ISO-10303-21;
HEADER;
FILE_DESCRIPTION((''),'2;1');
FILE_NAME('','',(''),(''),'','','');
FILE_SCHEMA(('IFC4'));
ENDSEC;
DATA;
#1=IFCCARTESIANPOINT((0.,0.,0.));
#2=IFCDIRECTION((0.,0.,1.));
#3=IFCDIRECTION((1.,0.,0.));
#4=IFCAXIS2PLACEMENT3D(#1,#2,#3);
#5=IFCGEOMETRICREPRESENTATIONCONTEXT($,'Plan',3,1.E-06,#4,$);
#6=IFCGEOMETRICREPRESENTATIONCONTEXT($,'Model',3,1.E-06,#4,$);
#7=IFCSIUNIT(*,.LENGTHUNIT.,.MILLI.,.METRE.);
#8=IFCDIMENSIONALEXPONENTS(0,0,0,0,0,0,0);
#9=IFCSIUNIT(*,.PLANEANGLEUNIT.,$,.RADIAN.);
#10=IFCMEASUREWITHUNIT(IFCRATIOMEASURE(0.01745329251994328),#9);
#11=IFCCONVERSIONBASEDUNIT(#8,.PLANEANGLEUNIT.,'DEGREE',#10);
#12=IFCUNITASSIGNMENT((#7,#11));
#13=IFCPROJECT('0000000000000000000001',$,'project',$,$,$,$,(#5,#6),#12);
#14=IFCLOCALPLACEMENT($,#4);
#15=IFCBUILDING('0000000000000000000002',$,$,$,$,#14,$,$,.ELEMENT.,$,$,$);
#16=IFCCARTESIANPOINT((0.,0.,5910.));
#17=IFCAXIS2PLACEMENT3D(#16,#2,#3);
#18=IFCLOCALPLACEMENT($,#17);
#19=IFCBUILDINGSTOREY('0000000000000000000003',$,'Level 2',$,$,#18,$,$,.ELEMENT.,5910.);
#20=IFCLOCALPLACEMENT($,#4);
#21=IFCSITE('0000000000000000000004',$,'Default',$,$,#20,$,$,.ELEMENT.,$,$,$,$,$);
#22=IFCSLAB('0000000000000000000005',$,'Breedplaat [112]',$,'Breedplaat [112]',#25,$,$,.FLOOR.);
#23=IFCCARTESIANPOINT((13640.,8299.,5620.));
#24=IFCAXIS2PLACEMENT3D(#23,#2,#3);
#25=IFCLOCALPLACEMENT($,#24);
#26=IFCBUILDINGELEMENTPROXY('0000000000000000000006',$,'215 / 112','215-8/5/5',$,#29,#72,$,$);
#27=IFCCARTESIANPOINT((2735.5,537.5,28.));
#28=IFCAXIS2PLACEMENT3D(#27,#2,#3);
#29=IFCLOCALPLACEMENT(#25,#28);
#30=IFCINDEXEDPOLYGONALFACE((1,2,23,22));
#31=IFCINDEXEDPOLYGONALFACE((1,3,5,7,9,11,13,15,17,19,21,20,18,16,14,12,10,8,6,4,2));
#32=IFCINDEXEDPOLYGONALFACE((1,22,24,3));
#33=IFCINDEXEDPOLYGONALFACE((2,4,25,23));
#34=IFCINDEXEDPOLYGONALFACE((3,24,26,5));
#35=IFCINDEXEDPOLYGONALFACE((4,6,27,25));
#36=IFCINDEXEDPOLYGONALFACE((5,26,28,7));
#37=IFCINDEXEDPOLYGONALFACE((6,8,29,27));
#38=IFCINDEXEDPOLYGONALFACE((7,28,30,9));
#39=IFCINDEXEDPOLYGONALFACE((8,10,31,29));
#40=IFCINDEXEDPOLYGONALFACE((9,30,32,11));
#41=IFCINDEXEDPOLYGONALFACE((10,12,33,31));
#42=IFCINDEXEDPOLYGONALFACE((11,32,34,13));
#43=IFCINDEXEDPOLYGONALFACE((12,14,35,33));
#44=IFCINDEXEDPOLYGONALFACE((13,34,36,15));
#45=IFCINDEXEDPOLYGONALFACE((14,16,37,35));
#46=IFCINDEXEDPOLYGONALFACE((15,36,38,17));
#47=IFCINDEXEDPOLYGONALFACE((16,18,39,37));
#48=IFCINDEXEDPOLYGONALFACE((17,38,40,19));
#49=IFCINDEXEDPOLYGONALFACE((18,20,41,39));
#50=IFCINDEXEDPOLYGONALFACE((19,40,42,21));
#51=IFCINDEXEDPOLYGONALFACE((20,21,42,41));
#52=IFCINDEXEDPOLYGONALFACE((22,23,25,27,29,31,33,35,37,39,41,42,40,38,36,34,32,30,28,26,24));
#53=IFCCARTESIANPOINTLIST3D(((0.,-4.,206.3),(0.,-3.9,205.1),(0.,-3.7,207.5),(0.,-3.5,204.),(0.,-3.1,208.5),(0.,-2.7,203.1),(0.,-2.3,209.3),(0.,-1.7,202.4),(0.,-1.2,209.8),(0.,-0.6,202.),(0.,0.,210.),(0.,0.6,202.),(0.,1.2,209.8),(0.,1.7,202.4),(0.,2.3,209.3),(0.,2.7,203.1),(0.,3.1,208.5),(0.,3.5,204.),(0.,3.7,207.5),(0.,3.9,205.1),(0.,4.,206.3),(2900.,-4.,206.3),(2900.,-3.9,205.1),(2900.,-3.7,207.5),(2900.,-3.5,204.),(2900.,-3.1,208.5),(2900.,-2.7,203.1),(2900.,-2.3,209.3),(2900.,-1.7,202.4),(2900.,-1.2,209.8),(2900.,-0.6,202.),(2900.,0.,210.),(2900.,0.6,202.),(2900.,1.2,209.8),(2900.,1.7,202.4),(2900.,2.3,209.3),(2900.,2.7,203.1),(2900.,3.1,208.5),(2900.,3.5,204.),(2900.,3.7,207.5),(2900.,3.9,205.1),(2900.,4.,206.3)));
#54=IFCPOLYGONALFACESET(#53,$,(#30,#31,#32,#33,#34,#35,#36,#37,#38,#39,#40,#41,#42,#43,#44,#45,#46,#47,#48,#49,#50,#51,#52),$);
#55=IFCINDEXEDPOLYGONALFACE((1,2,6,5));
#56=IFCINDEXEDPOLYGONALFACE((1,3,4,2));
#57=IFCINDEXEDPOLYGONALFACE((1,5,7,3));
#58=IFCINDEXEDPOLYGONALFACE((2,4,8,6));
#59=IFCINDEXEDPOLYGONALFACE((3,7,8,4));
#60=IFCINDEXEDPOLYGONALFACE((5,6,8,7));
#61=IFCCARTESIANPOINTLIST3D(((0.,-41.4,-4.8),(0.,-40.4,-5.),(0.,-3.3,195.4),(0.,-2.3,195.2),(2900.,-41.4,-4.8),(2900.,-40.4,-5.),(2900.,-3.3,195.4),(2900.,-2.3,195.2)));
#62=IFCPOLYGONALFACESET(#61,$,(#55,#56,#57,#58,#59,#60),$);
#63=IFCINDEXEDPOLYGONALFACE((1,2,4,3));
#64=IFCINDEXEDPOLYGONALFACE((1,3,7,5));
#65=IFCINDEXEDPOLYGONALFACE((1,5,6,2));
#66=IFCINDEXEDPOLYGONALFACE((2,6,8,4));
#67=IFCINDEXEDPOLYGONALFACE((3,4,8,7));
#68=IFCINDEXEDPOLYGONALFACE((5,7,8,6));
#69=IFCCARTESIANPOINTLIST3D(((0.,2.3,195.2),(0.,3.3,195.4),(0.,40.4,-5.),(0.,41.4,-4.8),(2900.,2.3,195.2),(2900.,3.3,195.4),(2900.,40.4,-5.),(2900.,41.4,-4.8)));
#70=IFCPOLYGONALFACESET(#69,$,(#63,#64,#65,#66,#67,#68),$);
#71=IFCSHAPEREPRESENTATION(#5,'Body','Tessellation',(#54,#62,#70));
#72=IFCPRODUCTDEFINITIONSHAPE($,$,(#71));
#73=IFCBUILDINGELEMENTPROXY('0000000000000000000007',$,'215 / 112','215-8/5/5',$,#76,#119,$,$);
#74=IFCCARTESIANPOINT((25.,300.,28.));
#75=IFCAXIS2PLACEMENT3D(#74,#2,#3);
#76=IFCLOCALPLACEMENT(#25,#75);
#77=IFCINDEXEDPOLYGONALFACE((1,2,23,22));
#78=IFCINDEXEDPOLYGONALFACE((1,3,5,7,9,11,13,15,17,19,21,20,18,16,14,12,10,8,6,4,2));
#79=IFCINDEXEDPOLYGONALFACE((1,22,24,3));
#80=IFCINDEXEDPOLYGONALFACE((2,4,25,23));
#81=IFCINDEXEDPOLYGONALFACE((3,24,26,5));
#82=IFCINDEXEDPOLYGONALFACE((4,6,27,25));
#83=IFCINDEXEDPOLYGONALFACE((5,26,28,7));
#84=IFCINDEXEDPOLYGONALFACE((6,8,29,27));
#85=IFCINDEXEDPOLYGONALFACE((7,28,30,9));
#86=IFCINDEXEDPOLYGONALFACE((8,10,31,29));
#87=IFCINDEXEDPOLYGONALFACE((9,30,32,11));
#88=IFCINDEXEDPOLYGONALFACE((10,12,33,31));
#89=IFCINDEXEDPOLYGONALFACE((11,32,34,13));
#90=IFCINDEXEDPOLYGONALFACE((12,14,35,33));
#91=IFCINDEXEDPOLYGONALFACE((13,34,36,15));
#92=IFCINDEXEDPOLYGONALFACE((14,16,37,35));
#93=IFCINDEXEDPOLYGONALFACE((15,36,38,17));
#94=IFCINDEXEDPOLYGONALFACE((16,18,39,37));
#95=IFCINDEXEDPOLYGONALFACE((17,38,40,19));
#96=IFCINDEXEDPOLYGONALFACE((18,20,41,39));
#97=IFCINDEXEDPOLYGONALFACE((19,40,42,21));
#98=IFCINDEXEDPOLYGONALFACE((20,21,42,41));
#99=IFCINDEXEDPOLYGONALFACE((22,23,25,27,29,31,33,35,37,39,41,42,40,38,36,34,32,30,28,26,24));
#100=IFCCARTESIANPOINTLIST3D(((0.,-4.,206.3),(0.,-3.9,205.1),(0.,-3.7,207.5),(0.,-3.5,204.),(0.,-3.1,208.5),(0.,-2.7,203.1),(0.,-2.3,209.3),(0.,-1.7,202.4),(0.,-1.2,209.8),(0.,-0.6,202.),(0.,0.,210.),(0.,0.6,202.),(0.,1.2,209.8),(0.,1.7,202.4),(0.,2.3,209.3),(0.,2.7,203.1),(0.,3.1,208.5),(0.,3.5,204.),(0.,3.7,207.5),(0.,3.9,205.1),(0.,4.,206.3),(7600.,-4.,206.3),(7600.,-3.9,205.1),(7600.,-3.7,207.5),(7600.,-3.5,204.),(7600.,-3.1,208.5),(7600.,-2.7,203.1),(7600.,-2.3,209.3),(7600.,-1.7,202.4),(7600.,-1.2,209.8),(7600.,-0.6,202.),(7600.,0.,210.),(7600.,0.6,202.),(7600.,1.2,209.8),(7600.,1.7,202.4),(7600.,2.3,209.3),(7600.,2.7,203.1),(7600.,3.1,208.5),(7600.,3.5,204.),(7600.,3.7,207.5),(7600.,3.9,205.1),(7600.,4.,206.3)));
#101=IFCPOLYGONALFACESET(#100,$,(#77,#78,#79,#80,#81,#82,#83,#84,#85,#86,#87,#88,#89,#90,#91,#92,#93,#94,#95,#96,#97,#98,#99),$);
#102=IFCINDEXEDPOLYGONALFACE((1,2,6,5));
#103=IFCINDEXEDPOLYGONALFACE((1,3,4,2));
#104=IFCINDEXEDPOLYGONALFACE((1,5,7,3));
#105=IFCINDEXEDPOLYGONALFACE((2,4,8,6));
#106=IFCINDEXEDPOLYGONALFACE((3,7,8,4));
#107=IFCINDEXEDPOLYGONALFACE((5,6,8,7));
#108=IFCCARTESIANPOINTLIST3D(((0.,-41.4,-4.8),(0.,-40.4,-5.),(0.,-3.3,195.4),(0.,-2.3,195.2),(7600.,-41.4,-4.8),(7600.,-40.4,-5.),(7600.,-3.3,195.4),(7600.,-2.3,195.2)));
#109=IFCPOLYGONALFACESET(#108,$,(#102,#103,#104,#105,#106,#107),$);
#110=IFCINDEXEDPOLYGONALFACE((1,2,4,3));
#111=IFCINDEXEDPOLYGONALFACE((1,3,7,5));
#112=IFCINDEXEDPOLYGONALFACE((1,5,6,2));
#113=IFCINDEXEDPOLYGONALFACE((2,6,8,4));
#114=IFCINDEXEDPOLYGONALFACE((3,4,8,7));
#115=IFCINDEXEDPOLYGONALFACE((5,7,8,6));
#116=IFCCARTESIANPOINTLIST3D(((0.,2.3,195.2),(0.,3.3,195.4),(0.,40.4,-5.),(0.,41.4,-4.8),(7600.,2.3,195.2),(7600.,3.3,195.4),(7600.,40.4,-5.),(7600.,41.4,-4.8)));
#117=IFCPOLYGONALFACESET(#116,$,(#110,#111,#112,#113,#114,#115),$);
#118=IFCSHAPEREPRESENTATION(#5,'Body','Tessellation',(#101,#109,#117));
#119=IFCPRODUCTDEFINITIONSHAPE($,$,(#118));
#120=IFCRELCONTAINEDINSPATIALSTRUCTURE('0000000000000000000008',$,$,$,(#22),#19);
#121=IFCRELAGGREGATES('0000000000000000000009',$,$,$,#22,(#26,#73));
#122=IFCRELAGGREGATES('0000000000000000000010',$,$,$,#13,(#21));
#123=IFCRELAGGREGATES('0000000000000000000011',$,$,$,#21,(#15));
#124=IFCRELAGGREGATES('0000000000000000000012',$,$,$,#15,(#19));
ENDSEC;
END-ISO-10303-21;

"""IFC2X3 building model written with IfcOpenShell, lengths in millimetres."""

from ifc_helpers import new_model, entity, si_unit, converted_unit, frame, origin_with_axes, origin_2d_with_axis, place, context, project, spatial, rectangle, circle, extrude, element, aggregate, save


model = new_model("IFC2X3")

# Units and contexts
plan_context = context("Plan", 3, precision=1e-06, world=origin_with_axes())
model_context = context("Model", 3, precision=1e-06, world=origin_with_axes())
ifc_project = project(units=[si_unit("LENGTHUNIT", "METRE", prefix="MILLI"), converted_unit("PLANEANGLEUNIT", "DEGREE", entity("IfcRatioMeasure", 0.01745329251994328), si_unit("PLANEANGLEUNIT", "RADIAN"), dimensions=[0, 0, 0, 0, 0, 0, 0])], contexts=[plan_context, model_context])

# Site, building, storey
site_placement = place(None, origin_with_axes())
site = spatial("IfcSite", under=ifc_project, at=site_placement, Name="Default", CompositionType="ELEMENT")
building_placement = place(None, origin_with_axes())
building = spatial("IfcBuilding", under=site, at=building_placement, CompositionType="ELEMENT")
storey_placement = place(None, frame((0.0, 0.0, 5910.0), z_axis=(0.0, 0.0, 1.0), x_axis=(1.0, 0.0, 0.0)))
storey = spatial("IfcBuildingStorey", under=building, at=storey_placement, Name="Level 2", CompositionType="ELEMENT", Elevation=5910.0)

# Slab, building element proxies
slab_1_placement = place(None, frame((13640.0, 8299.0, 5620.0), z_axis=(0.0, 0.0, 1.0), x_axis=(1.0, 0.0, 0.0)))
slab_1 = element("IfcSlab", 1, at=slab_1_placement, inside=storey, Name="Breedplaat [112]", ObjectType="Breedplaat [112]", PredefinedType="FLOOR")
proxy_1_placement = place(slab_1_placement, frame((2735.5, 537.5, 28.0), z_axis=(0.0, 0.0, 1.0), x_axis=(1.0, 0.0, 0.0)))
proxy_1 = element("IfcBuildingElementProxy", 2, at=proxy_1_placement, Name="215 / 112", Description="215-8/5/5", context=plan_context, shape_type="SweptSolid", body=[
    extrude(circle(Radius=4.0, at=origin_2d_with_axis()), frame((0.0, 0.0, 206.0), z_axis=(1.0, 0.0, 0.0), x_axis=(0.0, 0.0, 1.0)), (0.0, 0.0, 1.0), 2900.0),
    extrude(rectangle(XDim=203.8, YDim=1.0, at=origin_2d_with_axis()), frame((0.0, -21.9, 95.2), z_axis=(1.0, 0.0, 0.0), x_axis=(0.0, 0.187112, 0.982339)), (0.0, 0.0, 1.0), 2900.0),
    extrude(rectangle(XDim=203.8, YDim=1.0, at=origin_2d_with_axis()), frame((0.0, 21.9, 95.2), z_axis=(1.0, 0.0, 0.0), x_axis=(0.0, -0.187112, 0.982339)), (0.0, 0.0, 1.0), 2900.0),
])
proxy_2_placement = place(slab_1_placement, frame((25.0, 300.0, 28.0), z_axis=(0.0, 0.0, 1.0), x_axis=(1.0, 0.0, 0.0)))
proxy_2 = element("IfcBuildingElementProxy", 3, at=proxy_2_placement, Name="215 / 112", Description="215-8/5/5", context=plan_context, shape_type="SweptSolid", body=[
    extrude(circle(Radius=4.0, at=origin_2d_with_axis()), frame((0.0, 0.0, 206.0), z_axis=(1.0, 0.0, 0.0), x_axis=(0.0, 0.0, 1.0)), (0.0, 0.0, 1.0), 7600.0),
    extrude(rectangle(XDim=203.8, YDim=1.0, at=origin_2d_with_axis()), frame((0.0, -21.9, 95.2), z_axis=(1.0, 0.0, 0.0), x_axis=(0.0, 0.187112, 0.982339)), (0.0, 0.0, 1.0), 7600.0),
    extrude(rectangle(XDim=203.8, YDim=1.0, at=origin_2d_with_axis()), frame((0.0, 21.9, 95.2), z_axis=(1.0, 0.0, 0.0), x_axis=(0.0, -0.187112, 0.982339)), (0.0, 0.0, 1.0), 7600.0),
])
aggregate(slab_1, [proxy_1, proxy_2])

save(model, "model.ifc")
